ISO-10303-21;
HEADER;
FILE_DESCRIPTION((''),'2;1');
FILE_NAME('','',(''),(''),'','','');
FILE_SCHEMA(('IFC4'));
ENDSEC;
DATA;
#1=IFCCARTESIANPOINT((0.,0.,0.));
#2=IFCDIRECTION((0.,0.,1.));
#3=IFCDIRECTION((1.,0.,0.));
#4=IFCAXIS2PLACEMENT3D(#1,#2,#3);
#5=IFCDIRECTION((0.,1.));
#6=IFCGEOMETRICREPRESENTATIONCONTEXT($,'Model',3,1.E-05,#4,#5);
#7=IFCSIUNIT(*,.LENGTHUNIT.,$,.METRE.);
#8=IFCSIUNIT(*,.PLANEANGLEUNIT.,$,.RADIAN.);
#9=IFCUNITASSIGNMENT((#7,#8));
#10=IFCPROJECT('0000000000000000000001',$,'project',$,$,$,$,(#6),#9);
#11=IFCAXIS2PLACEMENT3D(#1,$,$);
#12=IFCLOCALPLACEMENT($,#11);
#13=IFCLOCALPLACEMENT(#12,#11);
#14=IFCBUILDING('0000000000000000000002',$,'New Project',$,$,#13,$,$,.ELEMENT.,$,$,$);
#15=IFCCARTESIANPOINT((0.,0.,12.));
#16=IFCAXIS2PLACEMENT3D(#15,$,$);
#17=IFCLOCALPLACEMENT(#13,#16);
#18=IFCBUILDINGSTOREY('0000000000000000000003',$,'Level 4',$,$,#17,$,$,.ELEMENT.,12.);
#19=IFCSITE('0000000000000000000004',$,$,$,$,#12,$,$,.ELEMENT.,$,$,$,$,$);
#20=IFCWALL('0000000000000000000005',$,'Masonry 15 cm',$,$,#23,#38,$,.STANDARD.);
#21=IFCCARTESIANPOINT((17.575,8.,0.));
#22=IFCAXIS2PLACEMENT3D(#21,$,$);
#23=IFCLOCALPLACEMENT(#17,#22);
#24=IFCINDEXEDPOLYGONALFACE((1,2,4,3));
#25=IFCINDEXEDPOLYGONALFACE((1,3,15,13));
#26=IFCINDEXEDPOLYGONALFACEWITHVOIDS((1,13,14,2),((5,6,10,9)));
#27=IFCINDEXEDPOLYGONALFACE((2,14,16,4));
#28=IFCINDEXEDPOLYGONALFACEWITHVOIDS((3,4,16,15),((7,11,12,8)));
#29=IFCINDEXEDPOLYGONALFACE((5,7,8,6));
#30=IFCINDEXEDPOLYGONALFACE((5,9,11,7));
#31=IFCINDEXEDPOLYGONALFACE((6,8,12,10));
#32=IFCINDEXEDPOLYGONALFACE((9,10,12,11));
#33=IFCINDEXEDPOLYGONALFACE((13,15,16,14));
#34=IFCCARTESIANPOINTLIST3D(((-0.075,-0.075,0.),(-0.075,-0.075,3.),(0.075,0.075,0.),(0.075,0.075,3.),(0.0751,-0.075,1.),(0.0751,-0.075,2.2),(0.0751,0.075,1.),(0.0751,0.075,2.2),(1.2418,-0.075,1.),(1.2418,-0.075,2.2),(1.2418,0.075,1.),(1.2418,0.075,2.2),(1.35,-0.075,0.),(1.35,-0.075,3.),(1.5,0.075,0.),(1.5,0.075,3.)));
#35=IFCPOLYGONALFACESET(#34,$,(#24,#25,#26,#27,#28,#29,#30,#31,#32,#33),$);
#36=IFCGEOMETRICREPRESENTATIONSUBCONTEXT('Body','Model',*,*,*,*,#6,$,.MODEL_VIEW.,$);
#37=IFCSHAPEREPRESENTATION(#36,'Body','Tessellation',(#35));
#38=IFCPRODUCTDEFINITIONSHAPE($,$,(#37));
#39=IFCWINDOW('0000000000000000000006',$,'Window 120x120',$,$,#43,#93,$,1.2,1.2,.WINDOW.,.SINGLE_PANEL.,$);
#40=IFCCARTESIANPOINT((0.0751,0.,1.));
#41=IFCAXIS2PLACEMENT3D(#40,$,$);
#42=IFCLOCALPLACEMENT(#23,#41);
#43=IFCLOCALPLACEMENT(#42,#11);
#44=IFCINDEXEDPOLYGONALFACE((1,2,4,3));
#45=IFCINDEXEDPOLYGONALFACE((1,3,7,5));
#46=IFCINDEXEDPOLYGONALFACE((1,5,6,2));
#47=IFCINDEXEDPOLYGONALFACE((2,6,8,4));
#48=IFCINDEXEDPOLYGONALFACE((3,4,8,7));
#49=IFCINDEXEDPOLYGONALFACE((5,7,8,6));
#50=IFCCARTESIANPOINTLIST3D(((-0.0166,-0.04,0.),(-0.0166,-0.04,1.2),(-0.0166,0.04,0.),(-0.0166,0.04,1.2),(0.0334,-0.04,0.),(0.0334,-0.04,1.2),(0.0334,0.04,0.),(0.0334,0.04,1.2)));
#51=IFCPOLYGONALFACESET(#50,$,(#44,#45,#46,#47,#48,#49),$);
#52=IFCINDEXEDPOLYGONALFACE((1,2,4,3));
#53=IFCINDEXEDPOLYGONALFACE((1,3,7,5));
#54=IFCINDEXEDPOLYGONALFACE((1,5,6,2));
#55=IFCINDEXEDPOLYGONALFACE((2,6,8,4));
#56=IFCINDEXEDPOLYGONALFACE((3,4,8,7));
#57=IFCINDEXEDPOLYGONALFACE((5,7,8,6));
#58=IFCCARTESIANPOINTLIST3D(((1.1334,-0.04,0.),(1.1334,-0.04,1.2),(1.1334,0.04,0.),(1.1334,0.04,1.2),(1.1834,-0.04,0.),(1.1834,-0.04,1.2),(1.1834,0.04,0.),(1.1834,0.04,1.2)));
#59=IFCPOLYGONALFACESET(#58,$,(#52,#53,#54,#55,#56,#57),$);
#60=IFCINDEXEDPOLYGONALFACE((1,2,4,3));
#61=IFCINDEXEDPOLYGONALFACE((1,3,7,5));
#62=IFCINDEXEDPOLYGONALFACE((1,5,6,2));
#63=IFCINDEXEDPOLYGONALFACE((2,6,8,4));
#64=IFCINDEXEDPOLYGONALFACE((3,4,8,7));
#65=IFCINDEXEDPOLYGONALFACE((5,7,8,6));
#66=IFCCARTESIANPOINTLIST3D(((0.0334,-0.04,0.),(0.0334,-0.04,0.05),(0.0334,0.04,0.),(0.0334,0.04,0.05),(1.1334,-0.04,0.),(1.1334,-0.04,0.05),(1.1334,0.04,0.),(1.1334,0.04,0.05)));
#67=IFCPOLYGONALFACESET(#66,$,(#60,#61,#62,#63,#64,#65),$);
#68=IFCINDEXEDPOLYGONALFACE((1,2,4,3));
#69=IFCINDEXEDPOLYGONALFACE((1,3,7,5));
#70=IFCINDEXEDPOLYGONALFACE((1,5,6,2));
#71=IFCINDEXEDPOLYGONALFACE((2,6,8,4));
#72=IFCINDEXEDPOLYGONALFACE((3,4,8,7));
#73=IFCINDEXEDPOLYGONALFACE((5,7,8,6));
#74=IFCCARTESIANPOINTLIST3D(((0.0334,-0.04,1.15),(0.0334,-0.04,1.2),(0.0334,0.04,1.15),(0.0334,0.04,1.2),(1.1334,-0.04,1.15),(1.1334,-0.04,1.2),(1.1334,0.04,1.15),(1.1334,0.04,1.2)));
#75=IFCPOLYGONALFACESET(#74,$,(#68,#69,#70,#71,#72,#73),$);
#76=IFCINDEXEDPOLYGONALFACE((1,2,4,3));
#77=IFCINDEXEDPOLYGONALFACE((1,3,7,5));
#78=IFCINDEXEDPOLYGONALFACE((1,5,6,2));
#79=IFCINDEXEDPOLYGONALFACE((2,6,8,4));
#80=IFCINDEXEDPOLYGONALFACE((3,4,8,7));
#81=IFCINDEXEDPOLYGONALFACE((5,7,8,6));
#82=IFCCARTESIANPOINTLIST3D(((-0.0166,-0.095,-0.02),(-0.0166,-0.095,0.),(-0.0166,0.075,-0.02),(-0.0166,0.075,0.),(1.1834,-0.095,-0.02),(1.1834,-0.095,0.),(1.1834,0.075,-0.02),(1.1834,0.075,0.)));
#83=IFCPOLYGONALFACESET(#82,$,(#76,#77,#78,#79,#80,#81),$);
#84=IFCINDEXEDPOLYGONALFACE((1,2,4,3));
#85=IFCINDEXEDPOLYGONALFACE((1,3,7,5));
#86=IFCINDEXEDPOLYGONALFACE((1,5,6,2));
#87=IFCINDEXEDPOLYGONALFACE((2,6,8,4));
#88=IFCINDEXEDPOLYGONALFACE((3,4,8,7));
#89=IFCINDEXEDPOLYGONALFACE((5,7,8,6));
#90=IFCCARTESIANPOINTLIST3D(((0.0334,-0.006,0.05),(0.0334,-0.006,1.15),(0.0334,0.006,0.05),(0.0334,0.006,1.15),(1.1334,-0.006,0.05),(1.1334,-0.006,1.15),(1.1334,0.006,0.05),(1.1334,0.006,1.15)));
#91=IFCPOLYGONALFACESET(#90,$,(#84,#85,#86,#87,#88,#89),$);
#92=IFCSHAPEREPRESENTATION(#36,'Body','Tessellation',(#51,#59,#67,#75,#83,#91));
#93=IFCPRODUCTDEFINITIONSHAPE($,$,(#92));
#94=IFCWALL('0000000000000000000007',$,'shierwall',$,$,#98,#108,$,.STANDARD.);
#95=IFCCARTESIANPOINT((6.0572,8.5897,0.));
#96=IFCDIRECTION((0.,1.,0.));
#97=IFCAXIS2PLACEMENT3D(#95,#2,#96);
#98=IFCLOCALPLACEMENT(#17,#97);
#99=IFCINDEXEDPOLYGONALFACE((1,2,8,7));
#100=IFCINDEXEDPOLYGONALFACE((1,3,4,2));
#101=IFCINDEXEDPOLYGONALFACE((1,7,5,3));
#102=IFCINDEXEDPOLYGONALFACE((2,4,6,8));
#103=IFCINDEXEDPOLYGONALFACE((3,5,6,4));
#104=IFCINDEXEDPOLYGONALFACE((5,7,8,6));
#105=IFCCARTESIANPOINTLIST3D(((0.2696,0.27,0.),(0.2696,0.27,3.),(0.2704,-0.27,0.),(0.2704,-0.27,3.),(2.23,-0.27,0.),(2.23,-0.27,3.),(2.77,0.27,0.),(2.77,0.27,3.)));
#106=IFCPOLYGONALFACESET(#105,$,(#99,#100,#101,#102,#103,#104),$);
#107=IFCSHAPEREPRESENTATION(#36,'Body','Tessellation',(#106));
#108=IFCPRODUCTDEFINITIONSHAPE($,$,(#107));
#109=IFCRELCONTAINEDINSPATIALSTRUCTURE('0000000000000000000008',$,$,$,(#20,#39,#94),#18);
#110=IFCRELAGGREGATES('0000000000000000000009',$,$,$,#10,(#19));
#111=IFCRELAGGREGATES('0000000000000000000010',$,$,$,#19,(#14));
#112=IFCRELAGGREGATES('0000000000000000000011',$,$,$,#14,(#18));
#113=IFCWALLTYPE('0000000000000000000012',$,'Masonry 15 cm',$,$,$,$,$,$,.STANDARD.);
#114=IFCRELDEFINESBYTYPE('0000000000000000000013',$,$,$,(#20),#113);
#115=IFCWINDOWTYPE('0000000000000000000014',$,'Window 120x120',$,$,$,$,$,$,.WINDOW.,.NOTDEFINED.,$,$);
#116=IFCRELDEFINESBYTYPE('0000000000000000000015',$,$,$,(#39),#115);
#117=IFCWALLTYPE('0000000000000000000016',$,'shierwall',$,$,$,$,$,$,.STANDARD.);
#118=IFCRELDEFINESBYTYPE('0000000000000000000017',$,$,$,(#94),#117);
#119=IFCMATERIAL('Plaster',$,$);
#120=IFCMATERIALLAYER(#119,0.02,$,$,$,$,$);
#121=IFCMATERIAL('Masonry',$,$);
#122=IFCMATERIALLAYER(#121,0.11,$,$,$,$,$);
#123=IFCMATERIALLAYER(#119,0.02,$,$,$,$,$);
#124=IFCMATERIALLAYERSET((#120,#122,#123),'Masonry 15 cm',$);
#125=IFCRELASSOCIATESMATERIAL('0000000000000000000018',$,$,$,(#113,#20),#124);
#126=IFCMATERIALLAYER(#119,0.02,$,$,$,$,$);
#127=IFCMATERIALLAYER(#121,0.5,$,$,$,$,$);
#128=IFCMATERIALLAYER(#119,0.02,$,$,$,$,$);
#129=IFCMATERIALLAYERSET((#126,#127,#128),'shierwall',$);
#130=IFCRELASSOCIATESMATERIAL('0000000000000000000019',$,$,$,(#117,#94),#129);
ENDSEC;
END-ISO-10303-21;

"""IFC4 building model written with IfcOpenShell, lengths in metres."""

from ifc_helpers import new_model, si_unit, direction, frame, frame_2d, origin, origin_with_axes, place, context, subcontext, project, spatial, polyline, rectangle, outline, extrude, material, layer, layer_set, layer_usage, type_object, element, fill, save


model = new_model("IFC4")

# Units and contexts
model_context = context("Model", 3, precision=1e-05, world=origin_with_axes(), true_north=direction((0.0, 1.0)))
body_context = subcontext(model_context, "Body", "Model", "MODEL_VIEW")
ifc_project = project(units=[si_unit("LENGTHUNIT", "METRE"), si_unit("PLANEANGLEUNIT", "RADIAN")], contexts=[model_context])

# Site, building, storey
site_placement = place(None, origin())
site = spatial("IfcSite", under=ifc_project, at=site_placement, CompositionType="ELEMENT")
building_placement = place(site_placement, origin())
building = spatial("IfcBuilding", under=site, at=building_placement, Name="New Project", CompositionType="ELEMENT")
storey_placement = place(building_placement, frame((0.0, 0.0, 12.0)))
storey = spatial("IfcBuildingStorey", under=building, at=storey_placement, Name="Level 4", CompositionType="ELEMENT", Elevation=12.0)

# Shared definitions
ifc_material_1 = material(Name="Plaster")
ifc_layer_1 = layer(ifc_material_1, 0.02)
ifc_material_2 = material(Name="Masonry")
ifc_layer_2 = layer(ifc_material_2, 0.11)
ifc_layer_3 = layer(ifc_material_1, 0.02)
ifc_layer_set_1 = layer_set([ifc_layer_1, ifc_layer_2, ifc_layer_3], Name="Masonry 15 cm")
ifc_layer_usage_1 = layer_usage(ifc_layer_set_1, "AXIS2", "NEGATIVE", 0.075)
wall_type_1 = type_object("IfcWallType", Name="Masonry 15 cm", PredefinedType="STANDARD", material=ifc_layer_set_1)
window_type = type_object("IfcWindowType", Name="Window 120x120", PartitioningType="NOTDEFINED", PredefinedType="WINDOW")

# Wall, opening, window
wall_1_placement = place(storey_placement, frame((17.575, 8.0, 0.0)))
wall_1 = element("IfcWall", 1, at=wall_1_placement, inside=storey, type_object=wall_type_1, material=ifc_layer_usage_1, Name="Masonry 15 cm", PredefinedType="STANDARD", context=body_context, shape_type="SweptSolid", body=[
    extrude(outline(polyline([(-0.075, -0.075), (1.35, -0.075), (1.5, 0.075), (0.075, 0.075), (-0.075, -0.075)])), origin(), (0.0, 0.0, 1.0), 3.0),
])
opening_1_placement = place(wall_1_placement, frame((0.0751, 0.0, 1.0)))
opening_1 = element("IfcOpeningElement", 2, at=opening_1_placement, cuts=wall_1, PredefinedType="OPENING", context=body_context, shape_type="SweptSolid", body=[
    extrude(rectangle(XDim=1.1667, YDim=0.25, at=frame_2d((0.5834, 0.0))), origin(), (0.0, 0.0, 1.0), 1.2),
])
window_1_placement = place(opening_1_placement, origin())
window_1 = element("IfcWindow", 3, at=window_1_placement, inside=storey, type_object=window_type, Name="Window 120x120", OverallHeight=1.2, OverallWidth=1.2, PartitioningType="SINGLE_PANEL", PredefinedType="WINDOW", context=body_context, shape_type="SweptSolid", body=[
    extrude(outline(polyline([(-0.0166, -0.04), (0.0334, -0.04), (0.0334, 0.04), (-0.0166, 0.04), (-0.0166, -0.04)])), origin(), (0.0, 0.0, 1.0), 1.2),
    extrude(outline(polyline([(1.1334, -0.04), (1.1834, -0.04), (1.1834, 0.04), (1.1334, 0.04), (1.1334, -0.04)])), origin(), (0.0, 0.0, 1.0), 1.2),
    extrude(outline(polyline([(0.0334, -0.04), (1.1334, -0.04), (1.1334, 0.04), (0.0334, 0.04), (0.0334, -0.04)])), origin(), (0.0, 0.0, 1.0), 0.05),
    extrude(outline(polyline([(0.0334, -0.04), (1.1334, -0.04), (1.1334, 0.04), (0.0334, 0.04), (0.0334, -0.04)])), frame((0.0, 0.0, 1.15)), (0.0, 0.0, 1.0), 0.05),
    extrude(outline(polyline([(-0.0166, -0.095), (1.1834, -0.095), (1.1834, 0.075), (-0.0166, 0.075), (-0.0166, -0.095)])), frame((0.0, 0.0, -0.02)), (0.0, 0.0, 1.0), 0.02),
    extrude(outline(polyline([(0.0334, -0.006), (1.1334, -0.006), (1.1334, 0.006), (0.0334, 0.006), (0.0334, -0.006)])), frame((0.0, 0.0, 0.05)), (0.0, 0.0, 1.0), 1.1),
])
fill(opening_1, window_1)

# Shared definitions
ifc_layer_4 = layer(ifc_material_1, 0.02)
ifc_layer_5 = layer(ifc_material_2, 0.5)
ifc_layer_6 = layer(ifc_material_1, 0.02)
ifc_layer_set_2 = layer_set([ifc_layer_4, ifc_layer_5, ifc_layer_6], Name="shierwall")
ifc_layer_usage_2 = layer_usage(ifc_layer_set_2, "AXIS2", "NEGATIVE", 0.27)
wall_type_2 = type_object("IfcWallType", Name="shierwall", PredefinedType="STANDARD", material=ifc_layer_set_2)

# Wall
wall_2_placement = place(storey_placement, frame((6.0572, 8.5897, 0.0), z_axis=(0.0, 0.0, 1.0), x_axis=(0.0, 1.0, 0.0)))
element("IfcWall", 4, at=wall_2_placement, inside=storey, type_object=wall_type_2, material=ifc_layer_usage_2, Name="shierwall", PredefinedType="STANDARD", context=body_context, shape_type="SweptSolid", body=[
    extrude(outline(polyline([(0.2704, -0.27), (2.23, -0.27), (2.77, 0.27), (0.2696, 0.27), (0.2704, -0.27)])), origin(), (0.0, 0.0, 1.0), 3.0),
])

save(model, "model.ifc")
